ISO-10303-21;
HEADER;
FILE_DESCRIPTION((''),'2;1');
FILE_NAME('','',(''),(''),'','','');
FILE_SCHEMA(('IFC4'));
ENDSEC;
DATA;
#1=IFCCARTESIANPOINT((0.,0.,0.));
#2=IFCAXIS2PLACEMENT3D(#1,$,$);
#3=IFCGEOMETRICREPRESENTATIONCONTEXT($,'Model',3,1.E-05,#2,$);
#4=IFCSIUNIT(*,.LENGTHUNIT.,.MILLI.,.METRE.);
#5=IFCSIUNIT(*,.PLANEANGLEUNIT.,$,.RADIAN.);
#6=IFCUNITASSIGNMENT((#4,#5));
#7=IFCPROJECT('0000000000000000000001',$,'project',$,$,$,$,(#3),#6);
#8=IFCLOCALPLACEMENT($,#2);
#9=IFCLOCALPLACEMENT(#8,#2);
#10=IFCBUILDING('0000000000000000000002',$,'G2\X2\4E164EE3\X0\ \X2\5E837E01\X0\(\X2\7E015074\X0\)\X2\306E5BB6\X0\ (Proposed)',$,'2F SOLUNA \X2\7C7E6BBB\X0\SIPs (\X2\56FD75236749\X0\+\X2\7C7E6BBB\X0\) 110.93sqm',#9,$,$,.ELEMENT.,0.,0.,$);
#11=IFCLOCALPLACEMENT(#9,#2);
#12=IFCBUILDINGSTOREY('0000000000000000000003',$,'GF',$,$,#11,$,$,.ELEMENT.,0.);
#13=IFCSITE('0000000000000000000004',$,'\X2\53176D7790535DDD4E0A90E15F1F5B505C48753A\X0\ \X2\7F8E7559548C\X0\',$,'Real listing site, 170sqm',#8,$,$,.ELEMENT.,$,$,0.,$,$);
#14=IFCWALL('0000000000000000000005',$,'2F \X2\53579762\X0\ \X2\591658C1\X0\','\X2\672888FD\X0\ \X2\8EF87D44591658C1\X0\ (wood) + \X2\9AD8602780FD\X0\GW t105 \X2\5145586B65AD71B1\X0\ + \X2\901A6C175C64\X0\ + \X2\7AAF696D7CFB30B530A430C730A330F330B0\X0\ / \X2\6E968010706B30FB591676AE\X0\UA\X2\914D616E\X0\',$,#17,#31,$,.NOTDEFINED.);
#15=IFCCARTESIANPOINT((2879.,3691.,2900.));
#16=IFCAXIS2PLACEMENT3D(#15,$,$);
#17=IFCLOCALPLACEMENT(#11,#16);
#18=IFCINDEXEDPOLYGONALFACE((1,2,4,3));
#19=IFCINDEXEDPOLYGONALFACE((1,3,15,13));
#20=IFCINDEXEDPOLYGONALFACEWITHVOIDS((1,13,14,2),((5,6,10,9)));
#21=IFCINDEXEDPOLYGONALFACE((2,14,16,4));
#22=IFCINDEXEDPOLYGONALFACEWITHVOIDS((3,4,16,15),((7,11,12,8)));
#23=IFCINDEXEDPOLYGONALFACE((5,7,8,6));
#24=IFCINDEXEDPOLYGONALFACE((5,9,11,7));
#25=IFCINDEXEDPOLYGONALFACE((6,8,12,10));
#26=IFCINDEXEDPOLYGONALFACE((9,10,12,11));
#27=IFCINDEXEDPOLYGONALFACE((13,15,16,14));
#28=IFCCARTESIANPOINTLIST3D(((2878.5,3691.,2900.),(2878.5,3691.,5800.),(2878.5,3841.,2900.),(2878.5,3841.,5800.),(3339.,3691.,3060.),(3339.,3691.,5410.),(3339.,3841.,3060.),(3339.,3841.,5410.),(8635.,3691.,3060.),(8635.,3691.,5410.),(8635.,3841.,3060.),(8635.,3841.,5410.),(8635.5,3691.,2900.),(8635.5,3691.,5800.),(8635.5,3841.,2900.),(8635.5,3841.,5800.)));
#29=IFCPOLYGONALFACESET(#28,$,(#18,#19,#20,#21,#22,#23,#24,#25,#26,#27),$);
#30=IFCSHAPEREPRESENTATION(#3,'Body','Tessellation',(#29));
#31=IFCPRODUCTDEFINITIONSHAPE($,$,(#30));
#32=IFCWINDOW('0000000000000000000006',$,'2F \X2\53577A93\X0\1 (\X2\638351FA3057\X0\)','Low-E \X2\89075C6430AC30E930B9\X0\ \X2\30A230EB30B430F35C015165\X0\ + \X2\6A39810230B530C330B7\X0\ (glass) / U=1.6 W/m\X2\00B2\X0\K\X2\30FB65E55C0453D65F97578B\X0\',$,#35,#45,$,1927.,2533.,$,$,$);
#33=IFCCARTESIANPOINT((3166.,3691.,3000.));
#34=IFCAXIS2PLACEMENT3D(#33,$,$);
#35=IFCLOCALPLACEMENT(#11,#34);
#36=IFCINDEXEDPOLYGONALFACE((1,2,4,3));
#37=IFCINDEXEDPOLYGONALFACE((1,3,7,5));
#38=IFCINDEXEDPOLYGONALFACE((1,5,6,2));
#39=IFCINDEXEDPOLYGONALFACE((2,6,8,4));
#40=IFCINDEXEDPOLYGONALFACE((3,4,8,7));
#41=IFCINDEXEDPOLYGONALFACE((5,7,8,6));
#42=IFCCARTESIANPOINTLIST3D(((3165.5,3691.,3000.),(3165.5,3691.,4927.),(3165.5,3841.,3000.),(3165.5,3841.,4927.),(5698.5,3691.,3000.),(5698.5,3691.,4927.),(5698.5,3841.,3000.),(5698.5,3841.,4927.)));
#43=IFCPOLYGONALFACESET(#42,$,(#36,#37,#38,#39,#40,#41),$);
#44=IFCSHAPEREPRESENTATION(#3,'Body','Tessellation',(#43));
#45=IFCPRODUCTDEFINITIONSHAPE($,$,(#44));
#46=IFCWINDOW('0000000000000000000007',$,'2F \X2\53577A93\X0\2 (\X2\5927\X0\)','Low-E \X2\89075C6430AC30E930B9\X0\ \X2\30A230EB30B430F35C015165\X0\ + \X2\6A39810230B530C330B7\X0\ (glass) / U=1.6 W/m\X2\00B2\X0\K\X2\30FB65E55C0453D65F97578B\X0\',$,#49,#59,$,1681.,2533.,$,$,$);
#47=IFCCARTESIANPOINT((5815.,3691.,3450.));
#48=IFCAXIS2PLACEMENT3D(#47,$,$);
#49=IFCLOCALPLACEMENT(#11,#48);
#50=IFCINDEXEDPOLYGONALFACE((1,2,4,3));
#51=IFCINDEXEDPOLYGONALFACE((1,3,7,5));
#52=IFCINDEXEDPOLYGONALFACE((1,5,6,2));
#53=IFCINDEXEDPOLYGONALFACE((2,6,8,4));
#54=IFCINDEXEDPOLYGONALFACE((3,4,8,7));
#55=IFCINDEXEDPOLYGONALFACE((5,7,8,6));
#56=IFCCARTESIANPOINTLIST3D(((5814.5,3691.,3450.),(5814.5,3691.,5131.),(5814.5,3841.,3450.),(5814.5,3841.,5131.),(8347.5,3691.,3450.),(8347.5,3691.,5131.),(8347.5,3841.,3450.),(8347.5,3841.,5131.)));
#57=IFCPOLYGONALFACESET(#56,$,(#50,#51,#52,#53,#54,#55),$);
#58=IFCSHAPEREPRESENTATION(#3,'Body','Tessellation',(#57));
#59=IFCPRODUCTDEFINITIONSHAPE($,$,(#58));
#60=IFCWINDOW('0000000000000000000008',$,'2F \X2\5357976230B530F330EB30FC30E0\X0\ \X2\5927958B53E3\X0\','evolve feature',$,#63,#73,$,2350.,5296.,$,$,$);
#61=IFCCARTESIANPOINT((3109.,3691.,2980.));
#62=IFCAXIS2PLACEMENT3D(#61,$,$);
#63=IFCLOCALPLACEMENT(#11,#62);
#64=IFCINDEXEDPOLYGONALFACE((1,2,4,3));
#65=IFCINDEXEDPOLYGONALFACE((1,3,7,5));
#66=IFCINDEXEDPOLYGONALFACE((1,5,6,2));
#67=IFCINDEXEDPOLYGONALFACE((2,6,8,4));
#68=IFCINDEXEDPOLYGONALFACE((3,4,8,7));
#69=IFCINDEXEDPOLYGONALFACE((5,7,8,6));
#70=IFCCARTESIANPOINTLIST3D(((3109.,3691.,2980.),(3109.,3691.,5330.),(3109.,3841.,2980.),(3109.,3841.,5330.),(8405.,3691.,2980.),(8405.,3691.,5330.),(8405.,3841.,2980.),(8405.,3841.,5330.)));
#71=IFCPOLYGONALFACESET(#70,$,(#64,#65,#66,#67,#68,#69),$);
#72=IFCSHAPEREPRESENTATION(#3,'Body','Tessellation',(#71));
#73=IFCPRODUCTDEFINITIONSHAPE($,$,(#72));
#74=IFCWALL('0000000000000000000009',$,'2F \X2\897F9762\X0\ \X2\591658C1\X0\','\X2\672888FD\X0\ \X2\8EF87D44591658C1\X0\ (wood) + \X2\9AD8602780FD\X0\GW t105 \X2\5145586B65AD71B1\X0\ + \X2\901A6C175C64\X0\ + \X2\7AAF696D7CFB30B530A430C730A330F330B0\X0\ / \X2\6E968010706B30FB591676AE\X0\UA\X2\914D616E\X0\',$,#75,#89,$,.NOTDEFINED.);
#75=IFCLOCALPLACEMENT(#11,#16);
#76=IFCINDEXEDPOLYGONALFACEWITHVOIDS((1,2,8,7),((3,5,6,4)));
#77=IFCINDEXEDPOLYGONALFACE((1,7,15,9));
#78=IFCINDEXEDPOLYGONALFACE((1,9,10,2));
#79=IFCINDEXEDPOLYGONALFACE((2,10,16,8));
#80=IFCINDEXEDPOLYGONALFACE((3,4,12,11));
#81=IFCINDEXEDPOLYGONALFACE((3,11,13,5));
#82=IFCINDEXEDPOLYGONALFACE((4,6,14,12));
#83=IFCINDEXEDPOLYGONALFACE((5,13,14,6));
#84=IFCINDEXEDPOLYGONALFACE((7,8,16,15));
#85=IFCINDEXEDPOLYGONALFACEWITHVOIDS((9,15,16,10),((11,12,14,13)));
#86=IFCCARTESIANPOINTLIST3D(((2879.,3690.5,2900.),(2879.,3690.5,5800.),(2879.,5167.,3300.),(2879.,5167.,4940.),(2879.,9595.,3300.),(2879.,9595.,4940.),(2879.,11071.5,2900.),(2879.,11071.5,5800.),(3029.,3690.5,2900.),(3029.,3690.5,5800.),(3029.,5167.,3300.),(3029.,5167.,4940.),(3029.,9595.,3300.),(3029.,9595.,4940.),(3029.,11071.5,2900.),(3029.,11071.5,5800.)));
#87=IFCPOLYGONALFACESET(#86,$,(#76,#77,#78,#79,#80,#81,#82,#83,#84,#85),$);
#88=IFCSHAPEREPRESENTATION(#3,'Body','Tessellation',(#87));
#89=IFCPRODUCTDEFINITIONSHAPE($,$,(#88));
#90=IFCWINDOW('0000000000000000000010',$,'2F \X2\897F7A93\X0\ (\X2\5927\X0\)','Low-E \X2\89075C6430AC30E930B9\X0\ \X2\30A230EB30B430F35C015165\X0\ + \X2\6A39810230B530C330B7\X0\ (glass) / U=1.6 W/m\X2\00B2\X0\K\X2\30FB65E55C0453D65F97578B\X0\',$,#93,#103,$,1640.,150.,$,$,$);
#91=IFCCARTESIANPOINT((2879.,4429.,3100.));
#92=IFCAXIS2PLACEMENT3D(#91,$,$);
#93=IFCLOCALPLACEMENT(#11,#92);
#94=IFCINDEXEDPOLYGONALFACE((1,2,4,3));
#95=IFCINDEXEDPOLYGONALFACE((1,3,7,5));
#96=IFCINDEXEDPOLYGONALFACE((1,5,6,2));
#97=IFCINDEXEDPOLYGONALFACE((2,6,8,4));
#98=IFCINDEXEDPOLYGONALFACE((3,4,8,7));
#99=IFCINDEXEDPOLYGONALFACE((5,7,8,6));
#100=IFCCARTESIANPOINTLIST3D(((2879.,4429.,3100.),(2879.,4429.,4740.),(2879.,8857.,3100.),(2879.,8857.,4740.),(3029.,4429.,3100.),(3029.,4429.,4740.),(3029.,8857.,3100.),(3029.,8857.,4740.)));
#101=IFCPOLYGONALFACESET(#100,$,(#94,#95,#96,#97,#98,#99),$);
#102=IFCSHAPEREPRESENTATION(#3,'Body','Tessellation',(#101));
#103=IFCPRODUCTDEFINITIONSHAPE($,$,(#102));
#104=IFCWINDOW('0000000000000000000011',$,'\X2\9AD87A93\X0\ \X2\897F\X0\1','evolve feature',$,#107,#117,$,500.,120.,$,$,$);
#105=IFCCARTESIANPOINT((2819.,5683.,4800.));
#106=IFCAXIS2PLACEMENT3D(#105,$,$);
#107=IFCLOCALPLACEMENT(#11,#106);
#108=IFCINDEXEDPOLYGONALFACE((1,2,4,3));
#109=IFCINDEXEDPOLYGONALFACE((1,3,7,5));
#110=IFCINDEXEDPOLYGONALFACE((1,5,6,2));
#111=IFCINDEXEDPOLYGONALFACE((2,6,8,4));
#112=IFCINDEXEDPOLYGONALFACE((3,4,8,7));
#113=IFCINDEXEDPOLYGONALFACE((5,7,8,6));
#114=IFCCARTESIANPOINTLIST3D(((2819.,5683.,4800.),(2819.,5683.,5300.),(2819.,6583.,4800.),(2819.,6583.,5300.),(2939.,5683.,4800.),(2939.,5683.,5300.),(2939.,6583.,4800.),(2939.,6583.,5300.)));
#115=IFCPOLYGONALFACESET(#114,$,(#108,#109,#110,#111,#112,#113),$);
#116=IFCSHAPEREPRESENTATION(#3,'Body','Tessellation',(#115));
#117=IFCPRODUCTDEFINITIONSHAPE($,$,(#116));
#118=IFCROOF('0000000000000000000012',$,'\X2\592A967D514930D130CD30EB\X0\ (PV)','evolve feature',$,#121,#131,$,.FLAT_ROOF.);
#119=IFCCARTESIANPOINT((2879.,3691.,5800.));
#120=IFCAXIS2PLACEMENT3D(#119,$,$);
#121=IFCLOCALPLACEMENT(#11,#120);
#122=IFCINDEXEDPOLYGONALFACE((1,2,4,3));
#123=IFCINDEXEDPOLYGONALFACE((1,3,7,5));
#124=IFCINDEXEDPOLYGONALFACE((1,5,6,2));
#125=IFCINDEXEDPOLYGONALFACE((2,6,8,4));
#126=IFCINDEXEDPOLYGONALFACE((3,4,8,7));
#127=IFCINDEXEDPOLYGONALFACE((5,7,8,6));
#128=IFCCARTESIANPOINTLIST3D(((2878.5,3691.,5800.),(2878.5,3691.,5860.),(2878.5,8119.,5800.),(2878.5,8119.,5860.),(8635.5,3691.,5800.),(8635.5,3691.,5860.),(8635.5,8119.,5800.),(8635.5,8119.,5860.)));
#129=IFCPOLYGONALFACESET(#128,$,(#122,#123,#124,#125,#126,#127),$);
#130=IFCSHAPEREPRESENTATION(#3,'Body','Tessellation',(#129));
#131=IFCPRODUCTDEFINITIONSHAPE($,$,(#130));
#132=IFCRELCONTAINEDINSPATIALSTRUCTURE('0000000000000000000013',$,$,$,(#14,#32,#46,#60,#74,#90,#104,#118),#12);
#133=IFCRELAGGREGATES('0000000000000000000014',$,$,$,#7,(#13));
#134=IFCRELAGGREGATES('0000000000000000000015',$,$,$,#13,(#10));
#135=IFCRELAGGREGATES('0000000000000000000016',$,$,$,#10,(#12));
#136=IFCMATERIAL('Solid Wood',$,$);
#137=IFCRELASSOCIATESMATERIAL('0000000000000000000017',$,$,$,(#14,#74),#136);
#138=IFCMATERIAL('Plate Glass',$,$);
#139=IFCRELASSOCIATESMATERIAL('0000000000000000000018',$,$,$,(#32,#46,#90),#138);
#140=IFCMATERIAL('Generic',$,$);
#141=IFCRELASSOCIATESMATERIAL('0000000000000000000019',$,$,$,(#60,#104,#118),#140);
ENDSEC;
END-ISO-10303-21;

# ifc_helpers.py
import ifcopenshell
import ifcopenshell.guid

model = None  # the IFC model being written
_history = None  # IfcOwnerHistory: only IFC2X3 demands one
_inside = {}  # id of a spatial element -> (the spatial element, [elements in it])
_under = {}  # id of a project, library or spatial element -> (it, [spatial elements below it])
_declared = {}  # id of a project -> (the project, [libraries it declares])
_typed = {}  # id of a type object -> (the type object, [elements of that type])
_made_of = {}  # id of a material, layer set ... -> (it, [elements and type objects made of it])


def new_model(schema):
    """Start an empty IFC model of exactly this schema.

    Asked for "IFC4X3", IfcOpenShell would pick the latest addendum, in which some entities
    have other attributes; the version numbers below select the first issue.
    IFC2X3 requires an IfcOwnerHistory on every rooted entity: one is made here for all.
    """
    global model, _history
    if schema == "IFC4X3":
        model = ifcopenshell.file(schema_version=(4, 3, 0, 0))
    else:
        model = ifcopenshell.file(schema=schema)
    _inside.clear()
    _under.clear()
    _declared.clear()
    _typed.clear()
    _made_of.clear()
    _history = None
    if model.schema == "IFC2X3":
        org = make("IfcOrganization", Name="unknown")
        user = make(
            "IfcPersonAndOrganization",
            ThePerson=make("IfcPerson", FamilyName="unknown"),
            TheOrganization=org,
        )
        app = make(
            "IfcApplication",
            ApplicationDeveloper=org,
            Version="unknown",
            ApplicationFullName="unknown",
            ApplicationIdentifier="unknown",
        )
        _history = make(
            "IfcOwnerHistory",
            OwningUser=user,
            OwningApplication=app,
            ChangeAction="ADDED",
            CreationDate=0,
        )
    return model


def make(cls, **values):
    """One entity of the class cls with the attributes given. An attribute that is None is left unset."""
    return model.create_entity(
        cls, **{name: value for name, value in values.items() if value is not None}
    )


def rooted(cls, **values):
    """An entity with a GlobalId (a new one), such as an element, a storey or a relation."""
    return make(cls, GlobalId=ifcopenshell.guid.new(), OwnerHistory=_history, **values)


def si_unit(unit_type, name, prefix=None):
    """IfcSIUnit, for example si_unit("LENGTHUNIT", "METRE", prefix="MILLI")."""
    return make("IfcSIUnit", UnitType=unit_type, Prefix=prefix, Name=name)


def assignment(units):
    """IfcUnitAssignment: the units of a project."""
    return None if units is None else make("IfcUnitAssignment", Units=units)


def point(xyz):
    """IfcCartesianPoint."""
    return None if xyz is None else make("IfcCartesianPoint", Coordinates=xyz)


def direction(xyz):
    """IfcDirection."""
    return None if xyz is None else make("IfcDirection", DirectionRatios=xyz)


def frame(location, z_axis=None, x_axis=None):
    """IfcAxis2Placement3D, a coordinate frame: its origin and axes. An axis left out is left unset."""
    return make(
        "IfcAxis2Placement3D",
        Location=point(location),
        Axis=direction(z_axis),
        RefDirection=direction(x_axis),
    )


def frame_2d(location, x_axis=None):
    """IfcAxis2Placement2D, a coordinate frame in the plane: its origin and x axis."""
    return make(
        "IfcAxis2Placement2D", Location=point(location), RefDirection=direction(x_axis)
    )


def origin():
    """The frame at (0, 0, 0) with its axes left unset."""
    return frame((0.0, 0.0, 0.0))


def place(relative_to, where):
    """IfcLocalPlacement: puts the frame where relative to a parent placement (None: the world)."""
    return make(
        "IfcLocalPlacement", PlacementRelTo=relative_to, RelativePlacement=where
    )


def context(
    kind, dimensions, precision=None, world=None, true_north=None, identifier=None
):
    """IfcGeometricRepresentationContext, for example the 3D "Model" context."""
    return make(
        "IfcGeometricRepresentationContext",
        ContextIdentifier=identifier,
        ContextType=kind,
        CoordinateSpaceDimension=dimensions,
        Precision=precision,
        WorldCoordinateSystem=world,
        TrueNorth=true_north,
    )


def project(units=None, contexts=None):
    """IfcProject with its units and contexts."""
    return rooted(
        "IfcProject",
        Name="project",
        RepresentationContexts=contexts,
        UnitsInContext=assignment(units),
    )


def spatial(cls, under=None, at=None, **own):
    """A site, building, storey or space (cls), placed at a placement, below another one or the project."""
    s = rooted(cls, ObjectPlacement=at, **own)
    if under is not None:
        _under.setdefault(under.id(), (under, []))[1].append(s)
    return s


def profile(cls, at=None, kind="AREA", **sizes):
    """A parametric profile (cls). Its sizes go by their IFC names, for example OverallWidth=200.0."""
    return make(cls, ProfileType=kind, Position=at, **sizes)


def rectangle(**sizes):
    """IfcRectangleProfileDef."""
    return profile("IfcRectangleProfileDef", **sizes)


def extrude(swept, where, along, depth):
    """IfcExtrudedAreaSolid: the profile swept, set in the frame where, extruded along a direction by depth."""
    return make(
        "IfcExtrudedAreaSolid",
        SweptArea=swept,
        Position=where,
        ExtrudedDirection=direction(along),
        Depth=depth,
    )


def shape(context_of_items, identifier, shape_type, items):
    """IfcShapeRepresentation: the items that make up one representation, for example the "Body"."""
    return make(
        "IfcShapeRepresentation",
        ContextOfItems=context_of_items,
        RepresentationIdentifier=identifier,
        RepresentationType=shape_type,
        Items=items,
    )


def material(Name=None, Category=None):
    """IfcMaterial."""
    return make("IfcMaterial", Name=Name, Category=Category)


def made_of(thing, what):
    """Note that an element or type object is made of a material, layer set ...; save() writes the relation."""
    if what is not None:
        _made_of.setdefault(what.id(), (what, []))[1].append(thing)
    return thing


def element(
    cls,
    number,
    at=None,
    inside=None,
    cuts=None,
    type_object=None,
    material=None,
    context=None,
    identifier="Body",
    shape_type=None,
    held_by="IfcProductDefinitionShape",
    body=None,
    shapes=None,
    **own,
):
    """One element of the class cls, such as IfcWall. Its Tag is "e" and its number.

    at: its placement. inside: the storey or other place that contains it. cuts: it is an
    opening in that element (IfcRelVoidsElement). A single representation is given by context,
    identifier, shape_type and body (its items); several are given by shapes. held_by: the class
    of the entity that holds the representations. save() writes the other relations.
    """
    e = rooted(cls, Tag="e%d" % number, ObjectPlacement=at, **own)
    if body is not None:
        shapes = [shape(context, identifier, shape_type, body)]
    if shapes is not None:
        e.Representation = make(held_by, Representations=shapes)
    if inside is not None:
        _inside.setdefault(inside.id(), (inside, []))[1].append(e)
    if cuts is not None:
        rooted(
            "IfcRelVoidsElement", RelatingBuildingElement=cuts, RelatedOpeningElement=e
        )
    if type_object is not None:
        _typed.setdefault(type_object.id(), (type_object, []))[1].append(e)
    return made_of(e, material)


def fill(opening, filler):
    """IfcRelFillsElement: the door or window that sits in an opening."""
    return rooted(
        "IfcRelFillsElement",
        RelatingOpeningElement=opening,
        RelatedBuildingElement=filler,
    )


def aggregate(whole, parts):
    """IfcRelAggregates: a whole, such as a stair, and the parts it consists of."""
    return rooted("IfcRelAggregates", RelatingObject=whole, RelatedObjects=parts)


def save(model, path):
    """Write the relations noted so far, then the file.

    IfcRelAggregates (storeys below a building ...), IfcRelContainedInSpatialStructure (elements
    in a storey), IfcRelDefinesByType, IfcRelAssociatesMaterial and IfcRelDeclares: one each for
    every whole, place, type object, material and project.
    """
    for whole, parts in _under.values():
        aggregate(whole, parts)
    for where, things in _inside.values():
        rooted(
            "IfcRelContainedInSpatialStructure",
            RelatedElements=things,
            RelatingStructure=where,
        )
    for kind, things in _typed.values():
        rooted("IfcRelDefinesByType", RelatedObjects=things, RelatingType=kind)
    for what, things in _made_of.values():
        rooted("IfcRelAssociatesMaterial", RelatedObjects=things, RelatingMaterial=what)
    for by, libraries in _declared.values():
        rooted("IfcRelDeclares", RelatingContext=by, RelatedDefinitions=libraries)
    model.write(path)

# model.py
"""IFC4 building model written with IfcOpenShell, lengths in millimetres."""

from ifc_helpers import new_model, si_unit, frame, frame_2d, origin, place, context, project, spatial, rectangle, extrude, material, element, fill, save


model = new_model("IFC4")

# Units and contexts
model_context = context("Model", 3, precision=1e-05, world=origin())
ifc_project = project(units=[si_unit("LENGTHUNIT", "METRE", prefix="MILLI"), si_unit("PLANEANGLEUNIT", "RADIAN")], contexts=[model_context])

# Site, building, storey
site_placement = place(None, origin())
site = spatial("IfcSite", under=ifc_project, at=site_placement, Name="北海道川上郡弟子屈町 美留和", ObjectType="Real listing site, 170sqm", CompositionType="ELEMENT", RefElevation=0.0)
building_placement = place(site_placement, origin())
building = spatial("IfcBuilding", under=site, at=building_placement, Name="G2世代 広縁(縁側)の家 (Proposed)", ObjectType="2F SOLUNA 籾殻SIPs (国産杉+籾殻) 110.93sqm", CompositionType="ELEMENT", ElevationOfRefHeight=0.0, ElevationOfTerrain=0.0)
storey_placement = place(building_placement, origin())
storey = spatial("IfcBuildingStorey", under=building, at=storey_placement, Name="GF", CompositionType="ELEMENT", Elevation=0.0)

# Shared definitions
ifc_material_1 = material(Name="Solid Wood")
ifc_material_2 = material(Name="Generic")

# Shared definitions
ifc_material_3 = material(Name="Plate Glass")

# Walls, openings, windows
wall_1_placement = place(storey_placement, frame((2879.0, 3691.0, 2900.0)))
wall_1 = element("IfcWall", 1, at=wall_1_placement, inside=storey, material=ifc_material_1, Name="2F 南面 外壁", Description="木製 軸組外壁 (wood) + 高性能GW t105 充填断熱 + 通気層 + 窯業系サイディング / 準耐火・外皮UA配慮", PredefinedType="NOTDEFINED", context=model_context, shape_type="SweptSolid", body=[
    extrude(rectangle(XDim=5757.0, YDim=150.0, at=frame_2d((2878.0, 75.0))), frame((2879.0, 3691.0, 2900.0)), (0.0, 0.0, 1.0), 2900.0),
])
opening_1_placement = place(storey_placement, frame((3166.0, 3691.0, 3000.0)))
opening_1 = element("IfcOpeningElement", 2, at=opening_1_placement, cuts=wall_1, PredefinedType="NOTDEFINED", context=model_context, shape_type="SweptSolid", body=[
    extrude(rectangle(XDim=2533.0, YDim=150.0, at=frame_2d((1266.0, 75.0))), frame((3166.0, 3691.0, 3000.0)), (0.0, 0.0, 1.0), 1927.0),
])
opening_2_placement = place(storey_placement, frame((5815.0, 3691.0, 3450.0)))
opening_2 = element("IfcOpeningElement", 3, at=opening_2_placement, cuts=wall_1, PredefinedType="NOTDEFINED", context=model_context, shape_type="SweptSolid", body=[
    extrude(rectangle(XDim=2533.0, YDim=150.0, at=frame_2d((1266.0, 75.0))), frame((5815.0, 3691.0, 3450.0)), (0.0, 0.0, 1.0), 1681.0),
])
opening_3_placement = place(storey_placement, frame((3109.0, 3691.0, 2980.0)))
opening_3 = element("IfcOpeningElement", 4, at=opening_3_placement, cuts=wall_1, PredefinedType="NOTDEFINED", context=model_context, shape_type="SweptSolid", body=[
    extrude(rectangle(XDim=5296.0, YDim=150.0, at=frame_2d((2648.0, 75.0))), frame((3109.0, 3691.0, 2980.0)), (0.0, 0.0, 1.0), 2350.0),
])
window_1_placement = place(storey_placement, frame((3166.0, 3691.0, 3000.0)))
window_1 = element("IfcWindow", 5, at=window_1_placement, inside=storey, material=ifc_material_3, Name="2F 南窓1 (掃出し)", Description="Low-E 複層ガラス アルゴン封入 + 樹脂サッシ (glass) / U=1.6 W/m²K・日射取得型", OverallHeight=1927.0, OverallWidth=2533.0, context=model_context, shape_type="SweptSolid", body=[
    extrude(rectangle(XDim=2533.0, YDim=150.0, at=frame_2d((1266.0, 75.0))), frame((3166.0, 3691.0, 3000.0)), (0.0, 0.0, 1.0), 1927.0),
])
fill(opening_1, window_1)
window_2_placement = place(storey_placement, frame((5815.0, 3691.0, 3450.0)))
window_2 = element("IfcWindow", 6, at=window_2_placement, inside=storey, material=ifc_material_3, Name="2F 南窓2 (大)", Description="Low-E 複層ガラス アルゴン封入 + 樹脂サッシ (glass) / U=1.6 W/m²K・日射取得型", OverallHeight=1681.0, OverallWidth=2533.0, context=model_context, shape_type="SweptSolid", body=[
    extrude(rectangle(XDim=2533.0, YDim=150.0, at=frame_2d((1266.0, 75.0))), frame((5815.0, 3691.0, 3450.0)), (0.0, 0.0, 1.0), 1681.0),
])
fill(opening_2, window_2)
window_3_placement = place(storey_placement, frame((3109.0, 3691.0, 2980.0)))
window_3 = element("IfcWindow", 7, at=window_3_placement, inside=storey, material=ifc_material_2, Name="2F 南面サンルーム 大開口", Description="evolve feature", OverallHeight=2350.0, OverallWidth=5296.0, context=model_context, shape_type="SweptSolid", body=[
    extrude(rectangle(XDim=5296.0, YDim=150.0, at=frame_2d((2648.0, 75.0))), frame((3109.0, 3691.0, 2980.0)), (0.0, 0.0, 1.0), 2350.0),
])
fill(opening_3, window_3)
wall_2_placement = place(storey_placement, frame((2879.0, 3691.0, 2900.0)))
wall_2 = element("IfcWall", 8, at=wall_2_placement, inside=storey, material=ifc_material_1, Name="2F 西面 外壁", Description="木製 軸組外壁 (wood) + 高性能GW t105 充填断熱 + 通気層 + 窯業系サイディング / 準耐火・外皮UA配慮", PredefinedType="NOTDEFINED", context=model_context, shape_type="SweptSolid", body=[
    extrude(rectangle(XDim=150.0, YDim=7381.0, at=frame_2d((75.0, 3690.0))), frame((2879.0, 3691.0, 2900.0)), (0.0, 0.0, 1.0), 2900.0),
])
opening_4_placement = place(storey_placement, frame((2879.0, 4429.0, 3100.0)))
opening_4 = element("IfcOpeningElement", 9, at=opening_4_placement, cuts=wall_2, PredefinedType="NOTDEFINED", context=model_context, shape_type="SweptSolid", body=[
    extrude(rectangle(XDim=150.0, YDim=4428.0, at=frame_2d((75.0, 2214.0))), frame((2879.0, 4429.0, 3100.0)), (0.0, 0.0, 1.0), 1640.0),
])
opening_5_placement = place(storey_placement, frame((2819.0, 5683.0, 4800.0)))
opening_5 = element("IfcOpeningElement", 10, at=opening_5_placement, cuts=wall_2, PredefinedType="NOTDEFINED", context=model_context, shape_type="SweptSolid", body=[
    extrude(rectangle(XDim=120.0, YDim=900.0, at=frame_2d((60.0, 450.0))), frame((2819.0, 5683.0, 4800.0)), (0.0, 0.0, 1.0), 500.0),
])
window_4_placement = place(storey_placement, frame((2879.0, 4429.0, 3100.0)))
window_4 = element("IfcWindow", 11, at=window_4_placement, inside=storey, material=ifc_material_3, Name="2F 西窓 (大)", Description="Low-E 複層ガラス アルゴン封入 + 樹脂サッシ (glass) / U=1.6 W/m²K・日射取得型", OverallHeight=1640.0, OverallWidth=150.0, context=model_context, shape_type="SweptSolid", body=[
    extrude(rectangle(XDim=150.0, YDim=4428.0, at=frame_2d((75.0, 2214.0))), frame((2879.0, 4429.0, 3100.0)), (0.0, 0.0, 1.0), 1640.0),
])
fill(opening_4, window_4)
window_5_placement = place(storey_placement, frame((2819.0, 5683.0, 4800.0)))
window_5 = element("IfcWindow", 12, at=window_5_placement, inside=storey, material=ifc_material_2, Name="高窓 西1", Description="evolve feature", OverallHeight=500.0, OverallWidth=120.0, context=model_context, shape_type="SweptSolid", body=[
    extrude(rectangle(XDim=120.0, YDim=900.0, at=frame_2d((60.0, 450.0))), frame((2819.0, 5683.0, 4800.0)), (0.0, 0.0, 1.0), 500.0),
])
fill(opening_5, window_5)

# Roof
roof_1_placement = place(storey_placement, frame((2879.0, 3691.0, 5800.0)))
element("IfcRoof", 13, at=roof_1_placement, inside=storey, material=ifc_material_2, Name="太陽光パネル (PV)", Description="evolve feature", PredefinedType="FLAT_ROOF", context=model_context, shape_type="SweptSolid", body=[
    extrude(rectangle(XDim=5757.0, YDim=4428.0, at=frame_2d((2878.0, 2214.0))), frame((2879.0, 3691.0, 5800.0)), (0.0, 0.0, 1.0), 60.0),
])

save(model, "model.ifc")
